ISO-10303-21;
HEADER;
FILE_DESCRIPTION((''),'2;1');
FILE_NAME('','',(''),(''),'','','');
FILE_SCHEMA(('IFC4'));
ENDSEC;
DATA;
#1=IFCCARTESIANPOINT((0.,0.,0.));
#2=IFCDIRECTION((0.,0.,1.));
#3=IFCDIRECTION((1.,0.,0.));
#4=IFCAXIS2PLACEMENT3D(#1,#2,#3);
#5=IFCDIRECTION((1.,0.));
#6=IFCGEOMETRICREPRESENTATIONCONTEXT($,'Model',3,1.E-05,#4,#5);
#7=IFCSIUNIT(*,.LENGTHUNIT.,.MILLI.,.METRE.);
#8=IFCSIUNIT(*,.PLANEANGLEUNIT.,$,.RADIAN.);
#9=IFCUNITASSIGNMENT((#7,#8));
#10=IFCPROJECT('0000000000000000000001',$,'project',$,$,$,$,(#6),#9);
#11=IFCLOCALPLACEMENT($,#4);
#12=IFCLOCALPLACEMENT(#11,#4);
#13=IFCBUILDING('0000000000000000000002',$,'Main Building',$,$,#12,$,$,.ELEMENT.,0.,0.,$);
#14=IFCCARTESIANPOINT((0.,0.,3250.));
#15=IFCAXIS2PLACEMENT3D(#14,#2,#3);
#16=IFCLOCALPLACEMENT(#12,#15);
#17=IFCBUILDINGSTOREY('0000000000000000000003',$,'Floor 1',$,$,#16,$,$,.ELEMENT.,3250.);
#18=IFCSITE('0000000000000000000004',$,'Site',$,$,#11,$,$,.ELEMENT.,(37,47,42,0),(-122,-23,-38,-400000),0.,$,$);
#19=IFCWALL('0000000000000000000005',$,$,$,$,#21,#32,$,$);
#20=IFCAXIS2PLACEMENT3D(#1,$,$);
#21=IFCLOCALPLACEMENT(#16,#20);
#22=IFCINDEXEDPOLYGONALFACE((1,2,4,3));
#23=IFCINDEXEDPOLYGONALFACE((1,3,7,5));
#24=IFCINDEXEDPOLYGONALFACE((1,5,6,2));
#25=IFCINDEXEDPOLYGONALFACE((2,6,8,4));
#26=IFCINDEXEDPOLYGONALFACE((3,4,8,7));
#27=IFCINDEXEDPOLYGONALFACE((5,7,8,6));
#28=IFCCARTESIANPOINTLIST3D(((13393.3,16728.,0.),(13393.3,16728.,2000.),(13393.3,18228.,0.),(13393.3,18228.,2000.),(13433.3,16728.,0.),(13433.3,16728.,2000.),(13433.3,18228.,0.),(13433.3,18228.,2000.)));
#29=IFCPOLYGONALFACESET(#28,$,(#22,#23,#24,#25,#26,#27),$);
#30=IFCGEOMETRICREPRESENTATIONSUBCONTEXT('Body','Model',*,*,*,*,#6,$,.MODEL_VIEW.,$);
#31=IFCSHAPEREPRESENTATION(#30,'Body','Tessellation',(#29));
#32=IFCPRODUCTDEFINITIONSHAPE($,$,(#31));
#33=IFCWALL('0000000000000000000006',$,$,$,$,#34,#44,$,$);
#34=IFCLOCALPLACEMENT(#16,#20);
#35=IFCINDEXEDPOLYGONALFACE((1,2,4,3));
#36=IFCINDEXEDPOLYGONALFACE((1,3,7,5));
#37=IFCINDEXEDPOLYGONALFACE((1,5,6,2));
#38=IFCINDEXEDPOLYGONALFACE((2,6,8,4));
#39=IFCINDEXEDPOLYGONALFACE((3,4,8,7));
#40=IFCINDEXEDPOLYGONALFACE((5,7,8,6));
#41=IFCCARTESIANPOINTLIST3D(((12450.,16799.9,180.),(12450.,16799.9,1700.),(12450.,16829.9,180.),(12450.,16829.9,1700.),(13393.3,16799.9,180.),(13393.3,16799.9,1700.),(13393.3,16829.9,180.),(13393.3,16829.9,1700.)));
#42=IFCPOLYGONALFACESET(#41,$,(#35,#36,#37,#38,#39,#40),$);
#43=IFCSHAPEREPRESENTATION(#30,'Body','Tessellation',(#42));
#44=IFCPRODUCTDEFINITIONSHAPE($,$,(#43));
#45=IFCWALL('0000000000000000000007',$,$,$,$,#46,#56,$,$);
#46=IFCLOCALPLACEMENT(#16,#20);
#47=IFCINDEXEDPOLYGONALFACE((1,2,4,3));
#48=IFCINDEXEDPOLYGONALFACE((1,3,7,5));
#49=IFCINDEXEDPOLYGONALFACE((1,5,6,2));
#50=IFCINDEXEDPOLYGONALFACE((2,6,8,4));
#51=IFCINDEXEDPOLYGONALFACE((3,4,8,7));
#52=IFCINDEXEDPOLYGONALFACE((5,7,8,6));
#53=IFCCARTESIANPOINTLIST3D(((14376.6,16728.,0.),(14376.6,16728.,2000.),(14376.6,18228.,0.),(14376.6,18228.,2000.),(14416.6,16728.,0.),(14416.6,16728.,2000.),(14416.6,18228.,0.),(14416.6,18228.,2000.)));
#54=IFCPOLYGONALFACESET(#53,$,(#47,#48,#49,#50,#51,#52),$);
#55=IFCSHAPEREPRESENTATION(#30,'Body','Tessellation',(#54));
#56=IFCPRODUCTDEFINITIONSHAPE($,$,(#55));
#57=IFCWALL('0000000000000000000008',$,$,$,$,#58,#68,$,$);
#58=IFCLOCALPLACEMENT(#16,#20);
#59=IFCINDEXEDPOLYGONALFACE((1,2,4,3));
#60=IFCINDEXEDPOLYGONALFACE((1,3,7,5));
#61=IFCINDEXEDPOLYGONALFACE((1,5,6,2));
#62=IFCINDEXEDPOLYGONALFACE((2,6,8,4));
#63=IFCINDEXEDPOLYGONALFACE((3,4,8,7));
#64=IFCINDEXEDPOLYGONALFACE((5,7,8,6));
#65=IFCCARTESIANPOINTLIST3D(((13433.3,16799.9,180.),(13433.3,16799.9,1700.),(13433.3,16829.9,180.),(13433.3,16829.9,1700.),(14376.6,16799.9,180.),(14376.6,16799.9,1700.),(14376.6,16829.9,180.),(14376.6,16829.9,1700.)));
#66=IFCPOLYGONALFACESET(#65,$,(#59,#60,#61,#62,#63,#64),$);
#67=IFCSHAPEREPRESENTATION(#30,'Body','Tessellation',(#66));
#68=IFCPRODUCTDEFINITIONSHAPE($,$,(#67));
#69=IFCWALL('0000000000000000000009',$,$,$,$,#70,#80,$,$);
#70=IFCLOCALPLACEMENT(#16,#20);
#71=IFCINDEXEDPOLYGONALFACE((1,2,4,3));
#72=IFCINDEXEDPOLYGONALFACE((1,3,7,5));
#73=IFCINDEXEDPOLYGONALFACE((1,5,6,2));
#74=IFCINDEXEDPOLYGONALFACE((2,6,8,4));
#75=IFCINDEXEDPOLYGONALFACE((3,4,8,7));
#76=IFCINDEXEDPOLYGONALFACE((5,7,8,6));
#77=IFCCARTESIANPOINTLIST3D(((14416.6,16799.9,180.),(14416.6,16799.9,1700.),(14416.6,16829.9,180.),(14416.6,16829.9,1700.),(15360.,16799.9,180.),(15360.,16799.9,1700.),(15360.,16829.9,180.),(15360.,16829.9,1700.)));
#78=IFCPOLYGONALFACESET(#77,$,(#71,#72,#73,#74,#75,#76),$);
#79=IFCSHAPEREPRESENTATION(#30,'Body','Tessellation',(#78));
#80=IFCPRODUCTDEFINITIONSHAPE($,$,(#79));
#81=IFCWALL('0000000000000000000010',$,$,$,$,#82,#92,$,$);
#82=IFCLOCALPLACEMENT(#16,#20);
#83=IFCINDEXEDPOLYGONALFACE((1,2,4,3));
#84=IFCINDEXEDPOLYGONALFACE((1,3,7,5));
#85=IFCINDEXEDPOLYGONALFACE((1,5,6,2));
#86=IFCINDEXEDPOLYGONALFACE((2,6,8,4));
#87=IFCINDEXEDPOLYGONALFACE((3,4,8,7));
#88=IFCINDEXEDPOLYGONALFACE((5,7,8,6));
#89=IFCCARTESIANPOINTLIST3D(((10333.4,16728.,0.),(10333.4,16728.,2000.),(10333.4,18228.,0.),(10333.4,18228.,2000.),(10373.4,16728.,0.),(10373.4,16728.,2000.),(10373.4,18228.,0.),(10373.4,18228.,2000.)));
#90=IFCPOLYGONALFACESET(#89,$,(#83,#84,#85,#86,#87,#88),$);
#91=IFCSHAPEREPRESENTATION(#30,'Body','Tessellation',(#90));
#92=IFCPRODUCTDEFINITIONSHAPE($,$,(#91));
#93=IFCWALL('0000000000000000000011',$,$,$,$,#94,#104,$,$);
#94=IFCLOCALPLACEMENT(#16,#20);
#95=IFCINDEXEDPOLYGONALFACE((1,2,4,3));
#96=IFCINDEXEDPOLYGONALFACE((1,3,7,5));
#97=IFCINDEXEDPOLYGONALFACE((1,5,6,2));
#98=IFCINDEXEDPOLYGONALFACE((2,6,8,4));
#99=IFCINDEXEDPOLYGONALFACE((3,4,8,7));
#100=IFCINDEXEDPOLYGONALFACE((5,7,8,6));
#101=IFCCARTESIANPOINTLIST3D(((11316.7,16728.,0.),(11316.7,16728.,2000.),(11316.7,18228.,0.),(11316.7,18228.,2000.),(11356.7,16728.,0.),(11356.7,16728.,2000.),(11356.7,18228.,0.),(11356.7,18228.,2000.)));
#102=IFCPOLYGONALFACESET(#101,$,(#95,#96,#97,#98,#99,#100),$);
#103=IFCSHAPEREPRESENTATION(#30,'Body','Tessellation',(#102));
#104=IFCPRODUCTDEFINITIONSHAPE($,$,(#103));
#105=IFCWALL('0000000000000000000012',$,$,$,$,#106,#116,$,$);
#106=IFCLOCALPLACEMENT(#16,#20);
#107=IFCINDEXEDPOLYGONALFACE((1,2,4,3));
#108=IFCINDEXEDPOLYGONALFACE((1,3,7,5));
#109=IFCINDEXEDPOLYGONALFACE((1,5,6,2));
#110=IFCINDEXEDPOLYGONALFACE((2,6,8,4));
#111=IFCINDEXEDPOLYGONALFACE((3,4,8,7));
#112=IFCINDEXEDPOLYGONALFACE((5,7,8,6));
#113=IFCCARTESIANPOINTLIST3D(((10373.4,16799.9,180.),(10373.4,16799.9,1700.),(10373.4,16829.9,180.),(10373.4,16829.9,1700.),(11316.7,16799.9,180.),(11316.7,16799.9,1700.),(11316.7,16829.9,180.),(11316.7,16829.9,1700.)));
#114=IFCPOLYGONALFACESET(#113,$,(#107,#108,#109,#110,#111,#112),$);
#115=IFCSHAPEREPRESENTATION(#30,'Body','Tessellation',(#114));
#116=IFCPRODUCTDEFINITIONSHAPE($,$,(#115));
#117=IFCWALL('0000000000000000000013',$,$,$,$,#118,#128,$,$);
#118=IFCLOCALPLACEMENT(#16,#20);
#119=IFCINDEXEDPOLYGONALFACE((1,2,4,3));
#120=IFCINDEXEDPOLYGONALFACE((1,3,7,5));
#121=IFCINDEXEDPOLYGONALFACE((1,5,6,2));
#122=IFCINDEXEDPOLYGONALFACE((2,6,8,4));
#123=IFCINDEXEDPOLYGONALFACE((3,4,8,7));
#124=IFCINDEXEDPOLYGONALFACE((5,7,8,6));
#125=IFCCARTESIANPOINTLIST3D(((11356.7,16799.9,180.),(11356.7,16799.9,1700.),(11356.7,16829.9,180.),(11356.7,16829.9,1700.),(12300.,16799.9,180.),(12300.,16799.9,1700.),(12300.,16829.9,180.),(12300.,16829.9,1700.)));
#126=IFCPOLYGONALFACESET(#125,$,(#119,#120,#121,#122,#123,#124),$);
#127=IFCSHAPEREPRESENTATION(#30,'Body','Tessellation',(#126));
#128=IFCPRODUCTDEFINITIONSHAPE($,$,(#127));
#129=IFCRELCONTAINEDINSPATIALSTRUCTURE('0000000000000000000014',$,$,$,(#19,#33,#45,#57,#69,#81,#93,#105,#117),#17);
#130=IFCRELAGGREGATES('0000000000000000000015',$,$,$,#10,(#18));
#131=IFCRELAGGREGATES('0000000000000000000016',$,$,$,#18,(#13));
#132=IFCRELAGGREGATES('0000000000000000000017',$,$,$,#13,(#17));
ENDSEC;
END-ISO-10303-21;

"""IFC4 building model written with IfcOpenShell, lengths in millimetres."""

from ifc_helpers import new_model, si_unit, direction, frame, frame_2d, origin_with_axes, origin_2d_with_axis, place, context, subcontext, project, spatial, rectangle, extrude, element, save


model = new_model("IFC4")

# Units and contexts
model_context = context("Model", 3, precision=1e-05, world=origin_with_axes(), true_north=direction((1.0, 0.0)))
body_context = subcontext(model_context, "Body", "Model", "MODEL_VIEW")
ifc_project = project(units=[si_unit("LENGTHUNIT", "METRE", prefix="MILLI"), si_unit("PLANEANGLEUNIT", "RADIAN")], contexts=[model_context])

# Site, building, storey
site_placement = place(None, origin_with_axes())
site = spatial("IfcSite", under=ifc_project, at=site_placement, Name="Site", CompositionType="ELEMENT", RefLatitude=(37, 47, 42, 0), RefLongitude=(-122, -23, -38, -400000), RefElevation=0.0)
building_placement = place(site_placement, origin_with_axes())
building = spatial("IfcBuilding", under=site, at=building_placement, Name="Main Building", CompositionType="ELEMENT", ElevationOfRefHeight=0.0, ElevationOfTerrain=0.0)
storey_placement = place(building_placement, frame((0.0, 0.0, 3250.0), z_axis=(0.0, 0.0, 1.0), x_axis=(1.0, 0.0, 0.0)))
storey = spatial("IfcBuildingStorey", under=building, at=storey_placement, Name="Floor 1", CompositionType="ELEMENT", Elevation=3250.0)

# Walls
wall_1_placement = place(storey_placement, origin_with_axes())
element("IfcWall", 1, at=wall_1_placement, inside=storey, context=body_context, shape_type="SweptSolid", body=[
    extrude(rectangle(XDim=1500.0, YDim=40.0, at=frame_2d((0.0, 0.0), x_axis=(0.0, 1.0))), frame((13413.3, 17478.0, 0.0), z_axis=(0.0, 0.0, 1.0), x_axis=(1.0, 0.0, 0.0)), (0.0, 0.0, 1.0), 2000.0),
])
wall_2_placement = place(storey_placement, origin_with_axes())
element("IfcWall", 2, at=wall_2_placement, inside=storey, context=body_context, shape_type="SweptSolid", body=[
    extrude(rectangle(XDim=943.3, YDim=30.0, at=origin_2d_with_axis()), frame((12921.7, 16814.9, 180.0), z_axis=(0.0, 0.0, 1.0), x_axis=(1.0, 0.0, 0.0)), (0.0, 0.0, 1.0), 1520.0),
])
wall_3_placement = place(storey_placement, origin_with_axes())
element("IfcWall", 3, at=wall_3_placement, inside=storey, context=body_context, shape_type="SweptSolid", body=[
    extrude(rectangle(XDim=1500.0, YDim=40.0, at=frame_2d((0.0, 0.0), x_axis=(0.0, 1.0))), frame((14396.6, 17478.0, 0.0), z_axis=(0.0, 0.0, 1.0), x_axis=(1.0, 0.0, 0.0)), (0.0, 0.0, 1.0), 2000.0),
])
wall_4_placement = place(storey_placement, origin_with_axes())
element("IfcWall", 4, at=wall_4_placement, inside=storey, context=body_context, shape_type="SweptSolid", body=[
    extrude(rectangle(XDim=943.3, YDim=30.0, at=origin_2d_with_axis()), frame((13905.0, 16814.9, 180.0), z_axis=(0.0, 0.0, 1.0), x_axis=(1.0, 0.0, 0.0)), (0.0, 0.0, 1.0), 1520.0),
])
wall_5_placement = place(storey_placement, origin_with_axes())
element("IfcWall", 5, at=wall_5_placement, inside=storey, context=body_context, shape_type="SweptSolid", body=[
    extrude(rectangle(XDim=943.3, YDim=30.0, at=origin_2d_with_axis()), frame((14888.3, 16814.9, 180.0), z_axis=(0.0, 0.0, 1.0), x_axis=(1.0, 0.0, 0.0)), (0.0, 0.0, 1.0), 1520.0),
])
wall_6_placement = place(storey_placement, origin_with_axes())
element("IfcWall", 6, at=wall_6_placement, inside=storey, context=body_context, shape_type="SweptSolid", body=[
    extrude(rectangle(XDim=1500.0, YDim=40.0, at=frame_2d((0.0, 0.0), x_axis=(0.0, 1.0))), frame((10353.4, 17478.0, 0.0), z_axis=(0.0, 0.0, 1.0), x_axis=(1.0, 0.0, 0.0)), (0.0, 0.0, 1.0), 2000.0),
])
wall_7_placement = place(storey_placement, origin_with_axes())
element("IfcWall", 7, at=wall_7_placement, inside=storey, context=body_context, shape_type="SweptSolid", body=[
    extrude(rectangle(XDim=1500.0, YDim=40.0, at=frame_2d((0.0, 0.0), x_axis=(0.0, 1.0))), frame((11336.7, 17478.0, 0.0), z_axis=(0.0, 0.0, 1.0), x_axis=(1.0, 0.0, 0.0)), (0.0, 0.0, 1.0), 2000.0),
])
wall_8_placement = place(storey_placement, origin_with_axes())
element("IfcWall", 8, at=wall_8_placement, inside=storey, context=body_context, shape_type="SweptSolid", body=[
    extrude(rectangle(XDim=943.3, YDim=30.0, at=origin_2d_with_axis()), frame((10845.0, 16814.9, 180.0), z_axis=(0.0, 0.0, 1.0), x_axis=(1.0, 0.0, 0.0)), (0.0, 0.0, 1.0), 1520.0),
])
wall_9_placement = place(storey_placement, origin_with_axes())
element("IfcWall", 9, at=wall_9_placement, inside=storey, context=body_context, shape_type="SweptSolid", body=[
    extrude(rectangle(XDim=943.3, YDim=30.0, at=origin_2d_with_axis()), frame((11828.3, 16814.9, 180.0), z_axis=(0.0, 0.0, 1.0), x_axis=(1.0, 0.0, 0.0)), (0.0, 0.0, 1.0), 1520.0),
])

save(model, "model.ifc")
